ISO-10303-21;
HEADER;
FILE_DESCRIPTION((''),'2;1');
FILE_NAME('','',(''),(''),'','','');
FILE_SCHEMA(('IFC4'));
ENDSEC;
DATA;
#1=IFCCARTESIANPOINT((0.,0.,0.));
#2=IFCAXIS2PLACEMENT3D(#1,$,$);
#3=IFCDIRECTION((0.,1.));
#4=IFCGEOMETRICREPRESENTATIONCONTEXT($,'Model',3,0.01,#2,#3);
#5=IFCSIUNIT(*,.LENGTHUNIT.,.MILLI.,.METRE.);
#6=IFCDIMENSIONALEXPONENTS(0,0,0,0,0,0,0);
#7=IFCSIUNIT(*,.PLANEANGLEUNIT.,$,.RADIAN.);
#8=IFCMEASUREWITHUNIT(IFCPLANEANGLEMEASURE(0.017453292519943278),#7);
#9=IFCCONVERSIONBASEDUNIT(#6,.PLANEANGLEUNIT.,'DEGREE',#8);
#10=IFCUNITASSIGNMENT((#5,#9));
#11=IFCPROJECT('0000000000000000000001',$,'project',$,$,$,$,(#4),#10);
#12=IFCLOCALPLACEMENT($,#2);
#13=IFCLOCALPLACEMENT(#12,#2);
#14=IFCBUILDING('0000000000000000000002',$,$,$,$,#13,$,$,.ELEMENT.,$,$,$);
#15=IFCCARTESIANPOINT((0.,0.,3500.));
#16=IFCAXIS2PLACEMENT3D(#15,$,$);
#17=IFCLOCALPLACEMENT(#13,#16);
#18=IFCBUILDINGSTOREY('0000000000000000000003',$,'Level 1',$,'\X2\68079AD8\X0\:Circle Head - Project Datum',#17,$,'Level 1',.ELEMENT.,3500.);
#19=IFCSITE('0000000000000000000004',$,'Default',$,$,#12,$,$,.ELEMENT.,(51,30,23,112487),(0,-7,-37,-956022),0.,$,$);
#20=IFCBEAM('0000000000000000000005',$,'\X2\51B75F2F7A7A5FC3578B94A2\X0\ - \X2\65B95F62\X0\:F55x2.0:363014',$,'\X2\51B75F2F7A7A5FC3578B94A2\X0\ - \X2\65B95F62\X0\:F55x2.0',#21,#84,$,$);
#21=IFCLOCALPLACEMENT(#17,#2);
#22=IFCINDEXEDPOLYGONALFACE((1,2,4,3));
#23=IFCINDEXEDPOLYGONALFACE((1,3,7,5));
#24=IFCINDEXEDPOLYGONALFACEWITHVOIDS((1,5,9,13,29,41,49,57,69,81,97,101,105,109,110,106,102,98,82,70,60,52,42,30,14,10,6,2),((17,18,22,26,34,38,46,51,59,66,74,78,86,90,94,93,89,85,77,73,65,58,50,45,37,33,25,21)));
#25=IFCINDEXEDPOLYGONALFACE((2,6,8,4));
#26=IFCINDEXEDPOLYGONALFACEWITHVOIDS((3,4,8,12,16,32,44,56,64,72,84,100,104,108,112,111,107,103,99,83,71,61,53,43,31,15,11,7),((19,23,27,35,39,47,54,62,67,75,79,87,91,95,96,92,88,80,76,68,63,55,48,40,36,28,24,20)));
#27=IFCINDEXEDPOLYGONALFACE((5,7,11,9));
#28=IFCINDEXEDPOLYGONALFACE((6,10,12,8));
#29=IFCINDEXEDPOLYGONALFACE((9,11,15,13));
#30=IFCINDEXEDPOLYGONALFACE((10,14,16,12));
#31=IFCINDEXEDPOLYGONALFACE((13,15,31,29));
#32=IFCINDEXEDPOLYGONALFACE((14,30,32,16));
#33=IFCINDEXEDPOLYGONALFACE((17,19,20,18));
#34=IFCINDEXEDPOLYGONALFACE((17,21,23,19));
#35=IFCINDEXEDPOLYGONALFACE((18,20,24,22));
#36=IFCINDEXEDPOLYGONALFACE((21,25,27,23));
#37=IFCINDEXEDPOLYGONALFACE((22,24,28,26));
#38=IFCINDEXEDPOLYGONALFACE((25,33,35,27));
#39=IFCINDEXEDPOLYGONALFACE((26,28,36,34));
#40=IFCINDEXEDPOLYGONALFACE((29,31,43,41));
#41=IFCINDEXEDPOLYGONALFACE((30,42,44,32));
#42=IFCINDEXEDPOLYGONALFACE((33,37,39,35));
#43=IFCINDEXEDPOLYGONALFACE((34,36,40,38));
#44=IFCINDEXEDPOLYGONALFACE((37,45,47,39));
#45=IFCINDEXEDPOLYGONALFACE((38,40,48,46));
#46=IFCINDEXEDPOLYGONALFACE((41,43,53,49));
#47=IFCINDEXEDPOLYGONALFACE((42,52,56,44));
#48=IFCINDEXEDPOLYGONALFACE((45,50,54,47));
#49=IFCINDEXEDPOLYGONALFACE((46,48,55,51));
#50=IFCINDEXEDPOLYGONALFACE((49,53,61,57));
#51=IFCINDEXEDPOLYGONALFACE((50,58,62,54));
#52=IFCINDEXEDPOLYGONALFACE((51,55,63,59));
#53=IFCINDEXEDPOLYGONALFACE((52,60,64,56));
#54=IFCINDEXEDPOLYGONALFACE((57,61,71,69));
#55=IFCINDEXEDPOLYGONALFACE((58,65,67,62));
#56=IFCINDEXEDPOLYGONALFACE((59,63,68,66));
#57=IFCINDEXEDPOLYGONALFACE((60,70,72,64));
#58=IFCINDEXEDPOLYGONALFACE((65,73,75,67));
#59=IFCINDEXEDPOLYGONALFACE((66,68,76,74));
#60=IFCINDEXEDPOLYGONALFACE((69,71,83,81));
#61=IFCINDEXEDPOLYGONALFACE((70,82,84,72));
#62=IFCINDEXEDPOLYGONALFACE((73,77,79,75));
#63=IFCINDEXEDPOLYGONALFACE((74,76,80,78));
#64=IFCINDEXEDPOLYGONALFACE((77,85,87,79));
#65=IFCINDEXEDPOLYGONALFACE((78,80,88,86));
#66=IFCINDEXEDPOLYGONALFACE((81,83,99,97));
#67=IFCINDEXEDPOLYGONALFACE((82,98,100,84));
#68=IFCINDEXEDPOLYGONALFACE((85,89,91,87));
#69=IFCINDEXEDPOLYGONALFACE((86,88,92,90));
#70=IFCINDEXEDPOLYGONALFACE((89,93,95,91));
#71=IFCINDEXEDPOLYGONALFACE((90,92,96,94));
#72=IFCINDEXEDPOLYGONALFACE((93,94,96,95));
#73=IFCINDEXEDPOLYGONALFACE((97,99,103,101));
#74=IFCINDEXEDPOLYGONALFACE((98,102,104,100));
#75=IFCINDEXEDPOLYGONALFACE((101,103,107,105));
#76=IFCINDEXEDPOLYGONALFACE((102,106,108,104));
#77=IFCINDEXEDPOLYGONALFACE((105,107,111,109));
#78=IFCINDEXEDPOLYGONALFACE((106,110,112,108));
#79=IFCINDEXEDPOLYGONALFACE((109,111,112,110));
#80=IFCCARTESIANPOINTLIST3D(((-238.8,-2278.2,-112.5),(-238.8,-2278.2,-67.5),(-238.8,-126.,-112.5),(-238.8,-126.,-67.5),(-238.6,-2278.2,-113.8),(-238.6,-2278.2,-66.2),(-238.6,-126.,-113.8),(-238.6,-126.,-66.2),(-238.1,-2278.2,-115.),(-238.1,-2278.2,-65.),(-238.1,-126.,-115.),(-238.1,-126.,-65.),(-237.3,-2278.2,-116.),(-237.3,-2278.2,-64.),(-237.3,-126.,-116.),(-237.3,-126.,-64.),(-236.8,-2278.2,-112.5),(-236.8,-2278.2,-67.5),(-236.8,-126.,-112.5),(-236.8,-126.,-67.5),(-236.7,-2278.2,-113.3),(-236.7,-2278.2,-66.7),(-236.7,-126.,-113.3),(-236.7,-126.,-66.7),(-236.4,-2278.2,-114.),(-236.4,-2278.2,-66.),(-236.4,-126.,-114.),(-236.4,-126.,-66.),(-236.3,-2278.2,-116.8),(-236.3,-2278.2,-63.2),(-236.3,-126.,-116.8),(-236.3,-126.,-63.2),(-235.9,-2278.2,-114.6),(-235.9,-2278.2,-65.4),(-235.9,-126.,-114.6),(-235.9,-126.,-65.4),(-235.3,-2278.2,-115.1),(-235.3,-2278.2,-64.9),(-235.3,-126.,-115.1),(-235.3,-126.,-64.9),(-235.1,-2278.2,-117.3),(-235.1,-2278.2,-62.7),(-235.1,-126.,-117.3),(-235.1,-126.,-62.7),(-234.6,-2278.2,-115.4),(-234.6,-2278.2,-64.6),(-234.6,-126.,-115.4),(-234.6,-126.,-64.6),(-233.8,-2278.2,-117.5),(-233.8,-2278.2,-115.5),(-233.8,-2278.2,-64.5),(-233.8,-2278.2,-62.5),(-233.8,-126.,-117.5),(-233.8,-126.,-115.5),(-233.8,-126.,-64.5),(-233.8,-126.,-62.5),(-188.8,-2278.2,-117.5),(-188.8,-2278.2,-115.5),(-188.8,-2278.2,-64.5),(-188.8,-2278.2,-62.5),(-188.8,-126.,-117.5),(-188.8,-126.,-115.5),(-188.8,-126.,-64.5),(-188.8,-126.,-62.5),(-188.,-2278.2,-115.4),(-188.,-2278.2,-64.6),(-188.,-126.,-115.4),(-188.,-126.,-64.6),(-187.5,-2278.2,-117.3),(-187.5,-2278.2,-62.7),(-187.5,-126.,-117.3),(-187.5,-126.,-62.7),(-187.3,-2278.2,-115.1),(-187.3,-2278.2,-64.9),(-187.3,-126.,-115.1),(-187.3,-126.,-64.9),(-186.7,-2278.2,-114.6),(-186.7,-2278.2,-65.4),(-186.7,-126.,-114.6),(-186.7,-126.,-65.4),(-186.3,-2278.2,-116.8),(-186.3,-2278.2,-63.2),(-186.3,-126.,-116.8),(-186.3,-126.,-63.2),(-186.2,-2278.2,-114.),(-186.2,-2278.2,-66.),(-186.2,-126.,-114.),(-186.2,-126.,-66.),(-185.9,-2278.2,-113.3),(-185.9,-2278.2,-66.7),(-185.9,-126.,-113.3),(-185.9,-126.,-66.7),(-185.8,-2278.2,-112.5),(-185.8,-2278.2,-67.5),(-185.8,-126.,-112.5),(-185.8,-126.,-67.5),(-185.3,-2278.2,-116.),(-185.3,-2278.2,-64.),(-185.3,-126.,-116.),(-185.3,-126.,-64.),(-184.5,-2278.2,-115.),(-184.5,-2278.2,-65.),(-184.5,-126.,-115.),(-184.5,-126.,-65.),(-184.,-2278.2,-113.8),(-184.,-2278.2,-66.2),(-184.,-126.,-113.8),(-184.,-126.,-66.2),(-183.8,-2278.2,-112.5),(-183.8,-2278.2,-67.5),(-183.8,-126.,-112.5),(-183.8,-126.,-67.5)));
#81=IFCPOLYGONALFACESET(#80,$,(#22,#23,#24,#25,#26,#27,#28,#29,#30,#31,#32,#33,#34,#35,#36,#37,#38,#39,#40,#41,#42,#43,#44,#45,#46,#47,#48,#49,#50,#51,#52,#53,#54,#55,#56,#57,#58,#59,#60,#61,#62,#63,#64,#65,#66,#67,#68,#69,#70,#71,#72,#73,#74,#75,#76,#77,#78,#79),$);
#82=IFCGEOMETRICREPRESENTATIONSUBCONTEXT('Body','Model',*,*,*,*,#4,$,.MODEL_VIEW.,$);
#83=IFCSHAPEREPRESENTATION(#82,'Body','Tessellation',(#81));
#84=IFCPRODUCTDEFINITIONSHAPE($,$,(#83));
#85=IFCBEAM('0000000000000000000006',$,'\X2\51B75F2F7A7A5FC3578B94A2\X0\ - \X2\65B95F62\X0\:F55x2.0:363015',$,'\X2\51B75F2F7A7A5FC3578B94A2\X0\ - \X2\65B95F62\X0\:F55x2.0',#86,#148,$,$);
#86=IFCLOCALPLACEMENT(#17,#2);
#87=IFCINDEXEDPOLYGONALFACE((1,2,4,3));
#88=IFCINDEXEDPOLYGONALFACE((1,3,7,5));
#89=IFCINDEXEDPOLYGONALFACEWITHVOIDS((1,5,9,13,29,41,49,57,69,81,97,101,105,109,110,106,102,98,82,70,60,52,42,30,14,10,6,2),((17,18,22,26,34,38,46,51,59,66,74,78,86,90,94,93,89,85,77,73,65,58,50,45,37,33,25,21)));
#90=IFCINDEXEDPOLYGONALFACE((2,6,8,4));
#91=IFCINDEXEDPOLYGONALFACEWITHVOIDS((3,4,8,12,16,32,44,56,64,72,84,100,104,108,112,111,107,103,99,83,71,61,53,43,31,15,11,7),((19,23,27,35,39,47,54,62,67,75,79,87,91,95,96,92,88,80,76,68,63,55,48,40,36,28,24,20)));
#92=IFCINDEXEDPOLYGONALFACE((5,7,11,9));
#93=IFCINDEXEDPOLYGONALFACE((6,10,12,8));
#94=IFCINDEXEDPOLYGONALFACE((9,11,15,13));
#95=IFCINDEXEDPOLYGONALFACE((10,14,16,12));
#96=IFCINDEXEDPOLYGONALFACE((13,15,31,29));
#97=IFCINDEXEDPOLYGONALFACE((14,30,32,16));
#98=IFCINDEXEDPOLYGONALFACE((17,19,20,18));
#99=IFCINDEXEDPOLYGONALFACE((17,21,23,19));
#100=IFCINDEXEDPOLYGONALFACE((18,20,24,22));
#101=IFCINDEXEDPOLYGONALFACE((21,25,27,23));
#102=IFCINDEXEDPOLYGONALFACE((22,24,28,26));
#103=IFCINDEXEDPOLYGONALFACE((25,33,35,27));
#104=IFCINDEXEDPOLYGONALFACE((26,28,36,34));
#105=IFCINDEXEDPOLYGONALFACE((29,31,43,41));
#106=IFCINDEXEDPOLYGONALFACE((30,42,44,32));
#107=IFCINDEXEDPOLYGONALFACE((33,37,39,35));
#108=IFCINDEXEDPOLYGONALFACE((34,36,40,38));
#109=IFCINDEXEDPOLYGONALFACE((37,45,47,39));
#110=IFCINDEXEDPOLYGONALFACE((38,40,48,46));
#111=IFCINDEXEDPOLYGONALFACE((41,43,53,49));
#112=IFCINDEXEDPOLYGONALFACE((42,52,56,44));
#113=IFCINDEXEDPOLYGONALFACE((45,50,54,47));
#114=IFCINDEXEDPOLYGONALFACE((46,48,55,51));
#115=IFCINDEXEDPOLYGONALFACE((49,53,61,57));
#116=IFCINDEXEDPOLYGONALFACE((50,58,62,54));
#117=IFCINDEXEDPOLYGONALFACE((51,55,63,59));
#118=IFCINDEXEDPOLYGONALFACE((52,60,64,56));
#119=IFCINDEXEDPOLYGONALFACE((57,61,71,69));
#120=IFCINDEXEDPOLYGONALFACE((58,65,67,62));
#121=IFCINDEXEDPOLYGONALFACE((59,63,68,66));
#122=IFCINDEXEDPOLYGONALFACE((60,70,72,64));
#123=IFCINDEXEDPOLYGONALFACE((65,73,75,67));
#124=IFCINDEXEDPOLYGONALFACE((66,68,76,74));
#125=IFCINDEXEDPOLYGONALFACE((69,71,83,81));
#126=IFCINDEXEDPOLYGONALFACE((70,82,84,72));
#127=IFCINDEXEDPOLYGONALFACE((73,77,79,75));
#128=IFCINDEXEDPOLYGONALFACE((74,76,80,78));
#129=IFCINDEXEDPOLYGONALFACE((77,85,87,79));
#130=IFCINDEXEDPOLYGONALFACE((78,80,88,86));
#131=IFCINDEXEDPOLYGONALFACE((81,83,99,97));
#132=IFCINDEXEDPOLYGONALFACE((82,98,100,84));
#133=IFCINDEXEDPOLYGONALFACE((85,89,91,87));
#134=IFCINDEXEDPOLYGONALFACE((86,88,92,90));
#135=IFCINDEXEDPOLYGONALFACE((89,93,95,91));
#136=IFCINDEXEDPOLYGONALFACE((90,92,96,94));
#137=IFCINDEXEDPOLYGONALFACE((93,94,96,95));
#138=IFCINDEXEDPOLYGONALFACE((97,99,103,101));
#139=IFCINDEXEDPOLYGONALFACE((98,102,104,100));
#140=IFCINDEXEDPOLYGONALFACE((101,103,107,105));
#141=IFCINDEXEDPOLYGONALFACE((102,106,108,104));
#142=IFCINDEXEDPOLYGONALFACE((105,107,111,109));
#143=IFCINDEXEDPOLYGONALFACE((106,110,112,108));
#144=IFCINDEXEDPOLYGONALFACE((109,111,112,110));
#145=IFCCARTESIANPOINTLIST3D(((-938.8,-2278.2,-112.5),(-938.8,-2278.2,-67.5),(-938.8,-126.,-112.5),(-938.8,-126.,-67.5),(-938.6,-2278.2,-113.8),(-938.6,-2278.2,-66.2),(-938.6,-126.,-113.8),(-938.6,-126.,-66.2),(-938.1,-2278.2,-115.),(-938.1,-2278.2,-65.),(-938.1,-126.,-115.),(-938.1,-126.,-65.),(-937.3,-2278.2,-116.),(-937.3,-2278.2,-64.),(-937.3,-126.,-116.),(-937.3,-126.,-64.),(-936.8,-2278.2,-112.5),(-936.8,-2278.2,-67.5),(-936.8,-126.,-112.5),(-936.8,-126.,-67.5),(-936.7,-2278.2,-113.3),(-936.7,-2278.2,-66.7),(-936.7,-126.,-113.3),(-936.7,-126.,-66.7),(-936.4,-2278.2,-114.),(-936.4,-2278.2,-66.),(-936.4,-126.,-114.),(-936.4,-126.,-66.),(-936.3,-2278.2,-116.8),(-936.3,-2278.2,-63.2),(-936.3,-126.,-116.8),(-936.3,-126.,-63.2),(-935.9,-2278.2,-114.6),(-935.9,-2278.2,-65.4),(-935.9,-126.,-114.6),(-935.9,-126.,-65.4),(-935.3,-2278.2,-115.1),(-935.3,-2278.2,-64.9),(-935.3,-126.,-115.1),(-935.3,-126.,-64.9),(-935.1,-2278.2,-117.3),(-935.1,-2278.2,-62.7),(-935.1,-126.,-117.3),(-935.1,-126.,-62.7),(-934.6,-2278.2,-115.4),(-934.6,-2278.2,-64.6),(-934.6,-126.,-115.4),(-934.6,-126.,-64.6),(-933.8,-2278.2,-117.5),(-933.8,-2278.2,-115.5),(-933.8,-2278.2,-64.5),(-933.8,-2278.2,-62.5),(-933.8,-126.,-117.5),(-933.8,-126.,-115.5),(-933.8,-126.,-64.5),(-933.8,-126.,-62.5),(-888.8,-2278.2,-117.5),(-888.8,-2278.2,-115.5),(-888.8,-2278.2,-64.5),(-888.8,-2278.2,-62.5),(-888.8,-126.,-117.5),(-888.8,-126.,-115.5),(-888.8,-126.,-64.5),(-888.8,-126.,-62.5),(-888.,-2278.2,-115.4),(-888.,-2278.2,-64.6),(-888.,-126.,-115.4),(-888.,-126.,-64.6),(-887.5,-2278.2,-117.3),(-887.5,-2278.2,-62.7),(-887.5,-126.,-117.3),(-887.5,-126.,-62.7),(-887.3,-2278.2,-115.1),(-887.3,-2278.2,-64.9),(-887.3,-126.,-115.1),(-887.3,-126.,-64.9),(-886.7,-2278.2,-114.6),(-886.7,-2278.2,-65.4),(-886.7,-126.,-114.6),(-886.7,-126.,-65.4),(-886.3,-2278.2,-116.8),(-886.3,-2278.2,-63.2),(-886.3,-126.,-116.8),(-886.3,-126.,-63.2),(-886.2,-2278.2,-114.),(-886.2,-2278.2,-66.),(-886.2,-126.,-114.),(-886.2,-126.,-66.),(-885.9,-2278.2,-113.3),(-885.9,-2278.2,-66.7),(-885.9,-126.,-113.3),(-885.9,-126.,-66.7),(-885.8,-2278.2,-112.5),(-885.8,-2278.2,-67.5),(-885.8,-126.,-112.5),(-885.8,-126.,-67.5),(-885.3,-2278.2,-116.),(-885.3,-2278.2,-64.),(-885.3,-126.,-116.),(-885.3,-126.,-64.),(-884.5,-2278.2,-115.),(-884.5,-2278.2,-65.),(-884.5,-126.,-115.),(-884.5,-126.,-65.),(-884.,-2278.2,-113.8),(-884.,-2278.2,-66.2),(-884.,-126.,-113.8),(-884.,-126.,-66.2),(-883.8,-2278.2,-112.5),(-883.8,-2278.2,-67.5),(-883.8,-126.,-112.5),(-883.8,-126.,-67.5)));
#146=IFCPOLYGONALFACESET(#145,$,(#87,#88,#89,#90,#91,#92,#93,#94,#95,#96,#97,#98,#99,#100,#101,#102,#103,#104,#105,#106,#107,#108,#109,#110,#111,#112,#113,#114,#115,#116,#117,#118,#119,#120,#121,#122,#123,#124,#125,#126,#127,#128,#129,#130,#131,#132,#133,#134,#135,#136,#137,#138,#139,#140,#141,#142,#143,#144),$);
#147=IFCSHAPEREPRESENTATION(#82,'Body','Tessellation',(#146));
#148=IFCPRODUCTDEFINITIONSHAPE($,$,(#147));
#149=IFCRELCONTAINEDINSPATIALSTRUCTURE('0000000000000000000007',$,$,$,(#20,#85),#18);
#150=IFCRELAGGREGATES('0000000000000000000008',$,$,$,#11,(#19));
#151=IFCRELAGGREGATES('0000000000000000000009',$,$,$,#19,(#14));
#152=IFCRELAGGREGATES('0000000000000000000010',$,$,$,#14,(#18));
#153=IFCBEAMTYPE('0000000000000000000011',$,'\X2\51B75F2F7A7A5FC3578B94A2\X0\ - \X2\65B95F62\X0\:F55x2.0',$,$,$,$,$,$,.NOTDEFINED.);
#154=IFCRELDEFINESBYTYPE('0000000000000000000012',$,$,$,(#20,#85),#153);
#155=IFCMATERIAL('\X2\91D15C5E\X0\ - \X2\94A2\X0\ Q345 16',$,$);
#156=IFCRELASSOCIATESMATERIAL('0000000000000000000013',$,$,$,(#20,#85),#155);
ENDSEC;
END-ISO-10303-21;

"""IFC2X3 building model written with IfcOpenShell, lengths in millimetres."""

from ifc_helpers import new_model, entity, si_unit, converted_unit, direction, frame, frame_2d, origin, place, context, subcontext, project, spatial, polyline, circle_curve, parameter, trimmed, segment, composite_curve, outline, extrude, material, type_object, element, save


model = new_model("IFC2X3")

# Units and contexts
model_context = context("Model", 3, precision=0.01, world=origin(), true_north=direction((0.0, 1.0)))
body_context = subcontext(model_context, "Body", "Model", "MODEL_VIEW")
ifc_project = project(units=[si_unit("LENGTHUNIT", "METRE", prefix="MILLI"), converted_unit("PLANEANGLEUNIT", "DEGREE", entity("IfcPlaneAngleMeasure", 0.017453292519943278), si_unit("PLANEANGLEUNIT", "RADIAN"), dimensions=[0, 0, 0, 0, 0, 0, 0])], contexts=[model_context])

# Site, building, storey
site_placement = place(None, origin())
site = spatial("IfcSite", under=ifc_project, at=site_placement, Name="Default", CompositionType="ELEMENT", RefLatitude=(51, 30, 23, 112487), RefLongitude=(0, -7, -37, -956022), RefElevation=0.0)
building_placement = place(site_placement, origin())
building = spatial("IfcBuilding", under=site, at=building_placement, CompositionType="ELEMENT")
storey_placement = place(building_placement, frame((0.0, 0.0, 3500.0)))
storey = spatial("IfcBuildingStorey", under=building, at=storey_placement, Name="Level 1", ObjectType="标高:Circle Head - Project Datum", LongName="Level 1", CompositionType="ELEMENT", Elevation=3500.0)

# Beams
ifc_material_1 = material(Name="金属 - 钢 Q345 16")
beam_type_1 = type_object("IfcBeamType", Name="冷弯空心型钢 - 方形:F55x2.0", PredefinedType="NOTDEFINED")
beam_1_placement = place(storey_placement, frame((-211.3, -390.5, -62.5), z_axis=(0.0, 0.0, 1.0), x_axis=(0.0, -1.0, 0.0)))
element("IfcBeam", 1, at=beam_1_placement, inside=storey, type_object=beam_type_1, material=ifc_material_1, Name="冷弯空心型钢 - 方形:F55x2.0:363014", ObjectType="冷弯空心型钢 - 方形:F55x2.0", context=body_context, shape_type="SweptSolid", body=[
    extrude(outline(composite_curve([segment(trimmed(circle_curve(frame_2d((-22.5, 22.5), x_axis=(1.0, 0.0)), 5.0), [parameter(90.0)], [parameter(180.0)], True, "PARAMETER"), True, "CONTINUOUS"), segment(polyline([(-27.5, 22.5), (-27.5, -22.5)]), True, "CONTINUOUS"), segment(trimmed(circle_curve(frame_2d((-22.5, -22.5), x_axis=(1.0, 0.0)), 5.0), [parameter(180.0)], [parameter(270.0)], True, "PARAMETER"), True, "CONTINUOUS"), segment(polyline([(-22.5, -27.5), (22.5, -27.5)]), True, "CONTINUOUS"), segment(trimmed(circle_curve(frame_2d((22.5, -22.5), x_axis=(1.0, 0.0)), 5.0), [parameter(270.0)], [parameter(0.0)], True, "PARAMETER"), True, "CONTINUOUS"), segment(polyline([(27.5, -22.5), (27.5, 22.5)]), True, "CONTINUOUS"), segment(trimmed(circle_curve(frame_2d((22.5, 22.5), x_axis=(1.0, 0.0)), 5.0), [parameter(0.0)], [parameter(90.0)], True, "PARAMETER"), True, "CONTINUOUS"), segment(polyline([(22.5, 27.5), (-22.5, 27.5)]), True, "CONTINUOUS")], self_intersect=False), holes=[composite_curve([segment(polyline([(-22.5, 25.5), (22.5, 25.5)]), True, "CONTINUOUS"), segment(trimmed(circle_curve(frame_2d((22.5, 22.5), x_axis=(1.0, 0.0)), 3.0), [parameter(0.0)], [parameter(90.0)], True, "PARAMETER"), False, "CONTINUOUS"), segment(polyline([(25.5, 22.5), (25.5, -22.5)]), True, "CONTINUOUS"), segment(trimmed(circle_curve(frame_2d((22.5, -22.5), x_axis=(1.0, 0.0)), 3.0), [parameter(270.0)], [parameter(360.0)], True, "PARAMETER"), False, "CONTINUOUS"), segment(polyline([(22.5, -25.5), (-22.5, -25.5)]), True, "CONTINUOUS"), segment(trimmed(circle_curve(frame_2d((-22.5, -22.5), x_axis=(1.0, 0.0)), 3.0), [parameter(180.0)], [parameter(270.0)], True, "PARAMETER"), False, "CONTINUOUS"), segment(polyline([(-25.5, -22.5), (-25.5, 22.5)]), True, "CONTINUOUS"), segment(trimmed(circle_curve(frame_2d((-22.5, 22.5), x_axis=(1.0, 0.0)), 3.0), [parameter(90.0)], [parameter(180.0)], True, "PARAMETER"), False, "CONTINUOUS")], self_intersect=False)]), frame((-264.5, 0.0, -27.5), z_axis=(1.0, 0.0, 0.0), x_axis=(0.0, 1.0, 0.0)), (0.0, 0.0, 1.0), 2152.2),
])
beam_2_placement = place(storey_placement, frame((-911.3, -390.5, -62.5), z_axis=(0.0, 0.0, 1.0), x_axis=(0.0, -1.0, 0.0)))
element("IfcBeam", 2, at=beam_2_placement, inside=storey, type_object=beam_type_1, material=ifc_material_1, Name="冷弯空心型钢 - 方形:F55x2.0:363015", ObjectType="冷弯空心型钢 - 方形:F55x2.0", context=body_context, shape_type="SweptSolid", body=[
    extrude(outline(composite_curve([segment(trimmed(circle_curve(frame_2d((-22.5, 22.5), x_axis=(1.0, 0.0)), 5.0), [parameter(90.0)], [parameter(180.0)], True, "PARAMETER"), True, "CONTINUOUS"), segment(polyline([(-27.5, 22.5), (-27.5, -22.5)]), True, "CONTINUOUS"), segment(trimmed(circle_curve(frame_2d((-22.5, -22.5), x_axis=(1.0, 0.0)), 5.0), [parameter(180.0)], [parameter(270.0)], True, "PARAMETER"), True, "CONTINUOUS"), segment(polyline([(-22.5, -27.5), (22.5, -27.5)]), True, "CONTINUOUS"), segment(trimmed(circle_curve(frame_2d((22.5, -22.5), x_axis=(1.0, 0.0)), 5.0), [parameter(270.0)], [parameter(0.0)], True, "PARAMETER"), True, "CONTINUOUS"), segment(polyline([(27.5, -22.5), (27.5, 22.5)]), True, "CONTINUOUS"), segment(trimmed(circle_curve(frame_2d((22.5, 22.5), x_axis=(1.0, 0.0)), 5.0), [parameter(0.0)], [parameter(90.0)], True, "PARAMETER"), True, "CONTINUOUS"), segment(polyline([(22.5, 27.5), (-22.5, 27.5)]), True, "CONTINUOUS")], self_intersect=False), holes=[composite_curve([segment(polyline([(-22.5, 25.5), (22.5, 25.5)]), True, "CONTINUOUS"), segment(trimmed(circle_curve(frame_2d((22.5, 22.5), x_axis=(1.0, 0.0)), 3.0), [parameter(0.0)], [parameter(90.0)], True, "PARAMETER"), False, "CONTINUOUS"), segment(polyline([(25.5, 22.5), (25.5, -22.5)]), True, "CONTINUOUS"), segment(trimmed(circle_curve(frame_2d((22.5, -22.5), x_axis=(1.0, 0.0)), 3.0), [parameter(270.0)], [parameter(360.0)], True, "PARAMETER"), False, "CONTINUOUS"), segment(polyline([(22.5, -25.5), (-22.5, -25.5)]), True, "CONTINUOUS"), segment(trimmed(circle_curve(frame_2d((-22.5, -22.5), x_axis=(1.0, 0.0)), 3.0), [parameter(180.0)], [parameter(270.0)], True, "PARAMETER"), False, "CONTINUOUS"), segment(polyline([(-25.5, -22.5), (-25.5, 22.5)]), True, "CONTINUOUS"), segment(trimmed(circle_curve(frame_2d((-22.5, 22.5), x_axis=(1.0, 0.0)), 3.0), [parameter(90.0)], [parameter(180.0)], True, "PARAMETER"), False, "CONTINUOUS")], self_intersect=False)]), frame((-264.5, 0.0, -27.5), z_axis=(1.0, 0.0, 0.0), x_axis=(0.0, 1.0, 0.0)), (0.0, 0.0, 1.0), 2152.2),
])

save(model, "model.ifc")
